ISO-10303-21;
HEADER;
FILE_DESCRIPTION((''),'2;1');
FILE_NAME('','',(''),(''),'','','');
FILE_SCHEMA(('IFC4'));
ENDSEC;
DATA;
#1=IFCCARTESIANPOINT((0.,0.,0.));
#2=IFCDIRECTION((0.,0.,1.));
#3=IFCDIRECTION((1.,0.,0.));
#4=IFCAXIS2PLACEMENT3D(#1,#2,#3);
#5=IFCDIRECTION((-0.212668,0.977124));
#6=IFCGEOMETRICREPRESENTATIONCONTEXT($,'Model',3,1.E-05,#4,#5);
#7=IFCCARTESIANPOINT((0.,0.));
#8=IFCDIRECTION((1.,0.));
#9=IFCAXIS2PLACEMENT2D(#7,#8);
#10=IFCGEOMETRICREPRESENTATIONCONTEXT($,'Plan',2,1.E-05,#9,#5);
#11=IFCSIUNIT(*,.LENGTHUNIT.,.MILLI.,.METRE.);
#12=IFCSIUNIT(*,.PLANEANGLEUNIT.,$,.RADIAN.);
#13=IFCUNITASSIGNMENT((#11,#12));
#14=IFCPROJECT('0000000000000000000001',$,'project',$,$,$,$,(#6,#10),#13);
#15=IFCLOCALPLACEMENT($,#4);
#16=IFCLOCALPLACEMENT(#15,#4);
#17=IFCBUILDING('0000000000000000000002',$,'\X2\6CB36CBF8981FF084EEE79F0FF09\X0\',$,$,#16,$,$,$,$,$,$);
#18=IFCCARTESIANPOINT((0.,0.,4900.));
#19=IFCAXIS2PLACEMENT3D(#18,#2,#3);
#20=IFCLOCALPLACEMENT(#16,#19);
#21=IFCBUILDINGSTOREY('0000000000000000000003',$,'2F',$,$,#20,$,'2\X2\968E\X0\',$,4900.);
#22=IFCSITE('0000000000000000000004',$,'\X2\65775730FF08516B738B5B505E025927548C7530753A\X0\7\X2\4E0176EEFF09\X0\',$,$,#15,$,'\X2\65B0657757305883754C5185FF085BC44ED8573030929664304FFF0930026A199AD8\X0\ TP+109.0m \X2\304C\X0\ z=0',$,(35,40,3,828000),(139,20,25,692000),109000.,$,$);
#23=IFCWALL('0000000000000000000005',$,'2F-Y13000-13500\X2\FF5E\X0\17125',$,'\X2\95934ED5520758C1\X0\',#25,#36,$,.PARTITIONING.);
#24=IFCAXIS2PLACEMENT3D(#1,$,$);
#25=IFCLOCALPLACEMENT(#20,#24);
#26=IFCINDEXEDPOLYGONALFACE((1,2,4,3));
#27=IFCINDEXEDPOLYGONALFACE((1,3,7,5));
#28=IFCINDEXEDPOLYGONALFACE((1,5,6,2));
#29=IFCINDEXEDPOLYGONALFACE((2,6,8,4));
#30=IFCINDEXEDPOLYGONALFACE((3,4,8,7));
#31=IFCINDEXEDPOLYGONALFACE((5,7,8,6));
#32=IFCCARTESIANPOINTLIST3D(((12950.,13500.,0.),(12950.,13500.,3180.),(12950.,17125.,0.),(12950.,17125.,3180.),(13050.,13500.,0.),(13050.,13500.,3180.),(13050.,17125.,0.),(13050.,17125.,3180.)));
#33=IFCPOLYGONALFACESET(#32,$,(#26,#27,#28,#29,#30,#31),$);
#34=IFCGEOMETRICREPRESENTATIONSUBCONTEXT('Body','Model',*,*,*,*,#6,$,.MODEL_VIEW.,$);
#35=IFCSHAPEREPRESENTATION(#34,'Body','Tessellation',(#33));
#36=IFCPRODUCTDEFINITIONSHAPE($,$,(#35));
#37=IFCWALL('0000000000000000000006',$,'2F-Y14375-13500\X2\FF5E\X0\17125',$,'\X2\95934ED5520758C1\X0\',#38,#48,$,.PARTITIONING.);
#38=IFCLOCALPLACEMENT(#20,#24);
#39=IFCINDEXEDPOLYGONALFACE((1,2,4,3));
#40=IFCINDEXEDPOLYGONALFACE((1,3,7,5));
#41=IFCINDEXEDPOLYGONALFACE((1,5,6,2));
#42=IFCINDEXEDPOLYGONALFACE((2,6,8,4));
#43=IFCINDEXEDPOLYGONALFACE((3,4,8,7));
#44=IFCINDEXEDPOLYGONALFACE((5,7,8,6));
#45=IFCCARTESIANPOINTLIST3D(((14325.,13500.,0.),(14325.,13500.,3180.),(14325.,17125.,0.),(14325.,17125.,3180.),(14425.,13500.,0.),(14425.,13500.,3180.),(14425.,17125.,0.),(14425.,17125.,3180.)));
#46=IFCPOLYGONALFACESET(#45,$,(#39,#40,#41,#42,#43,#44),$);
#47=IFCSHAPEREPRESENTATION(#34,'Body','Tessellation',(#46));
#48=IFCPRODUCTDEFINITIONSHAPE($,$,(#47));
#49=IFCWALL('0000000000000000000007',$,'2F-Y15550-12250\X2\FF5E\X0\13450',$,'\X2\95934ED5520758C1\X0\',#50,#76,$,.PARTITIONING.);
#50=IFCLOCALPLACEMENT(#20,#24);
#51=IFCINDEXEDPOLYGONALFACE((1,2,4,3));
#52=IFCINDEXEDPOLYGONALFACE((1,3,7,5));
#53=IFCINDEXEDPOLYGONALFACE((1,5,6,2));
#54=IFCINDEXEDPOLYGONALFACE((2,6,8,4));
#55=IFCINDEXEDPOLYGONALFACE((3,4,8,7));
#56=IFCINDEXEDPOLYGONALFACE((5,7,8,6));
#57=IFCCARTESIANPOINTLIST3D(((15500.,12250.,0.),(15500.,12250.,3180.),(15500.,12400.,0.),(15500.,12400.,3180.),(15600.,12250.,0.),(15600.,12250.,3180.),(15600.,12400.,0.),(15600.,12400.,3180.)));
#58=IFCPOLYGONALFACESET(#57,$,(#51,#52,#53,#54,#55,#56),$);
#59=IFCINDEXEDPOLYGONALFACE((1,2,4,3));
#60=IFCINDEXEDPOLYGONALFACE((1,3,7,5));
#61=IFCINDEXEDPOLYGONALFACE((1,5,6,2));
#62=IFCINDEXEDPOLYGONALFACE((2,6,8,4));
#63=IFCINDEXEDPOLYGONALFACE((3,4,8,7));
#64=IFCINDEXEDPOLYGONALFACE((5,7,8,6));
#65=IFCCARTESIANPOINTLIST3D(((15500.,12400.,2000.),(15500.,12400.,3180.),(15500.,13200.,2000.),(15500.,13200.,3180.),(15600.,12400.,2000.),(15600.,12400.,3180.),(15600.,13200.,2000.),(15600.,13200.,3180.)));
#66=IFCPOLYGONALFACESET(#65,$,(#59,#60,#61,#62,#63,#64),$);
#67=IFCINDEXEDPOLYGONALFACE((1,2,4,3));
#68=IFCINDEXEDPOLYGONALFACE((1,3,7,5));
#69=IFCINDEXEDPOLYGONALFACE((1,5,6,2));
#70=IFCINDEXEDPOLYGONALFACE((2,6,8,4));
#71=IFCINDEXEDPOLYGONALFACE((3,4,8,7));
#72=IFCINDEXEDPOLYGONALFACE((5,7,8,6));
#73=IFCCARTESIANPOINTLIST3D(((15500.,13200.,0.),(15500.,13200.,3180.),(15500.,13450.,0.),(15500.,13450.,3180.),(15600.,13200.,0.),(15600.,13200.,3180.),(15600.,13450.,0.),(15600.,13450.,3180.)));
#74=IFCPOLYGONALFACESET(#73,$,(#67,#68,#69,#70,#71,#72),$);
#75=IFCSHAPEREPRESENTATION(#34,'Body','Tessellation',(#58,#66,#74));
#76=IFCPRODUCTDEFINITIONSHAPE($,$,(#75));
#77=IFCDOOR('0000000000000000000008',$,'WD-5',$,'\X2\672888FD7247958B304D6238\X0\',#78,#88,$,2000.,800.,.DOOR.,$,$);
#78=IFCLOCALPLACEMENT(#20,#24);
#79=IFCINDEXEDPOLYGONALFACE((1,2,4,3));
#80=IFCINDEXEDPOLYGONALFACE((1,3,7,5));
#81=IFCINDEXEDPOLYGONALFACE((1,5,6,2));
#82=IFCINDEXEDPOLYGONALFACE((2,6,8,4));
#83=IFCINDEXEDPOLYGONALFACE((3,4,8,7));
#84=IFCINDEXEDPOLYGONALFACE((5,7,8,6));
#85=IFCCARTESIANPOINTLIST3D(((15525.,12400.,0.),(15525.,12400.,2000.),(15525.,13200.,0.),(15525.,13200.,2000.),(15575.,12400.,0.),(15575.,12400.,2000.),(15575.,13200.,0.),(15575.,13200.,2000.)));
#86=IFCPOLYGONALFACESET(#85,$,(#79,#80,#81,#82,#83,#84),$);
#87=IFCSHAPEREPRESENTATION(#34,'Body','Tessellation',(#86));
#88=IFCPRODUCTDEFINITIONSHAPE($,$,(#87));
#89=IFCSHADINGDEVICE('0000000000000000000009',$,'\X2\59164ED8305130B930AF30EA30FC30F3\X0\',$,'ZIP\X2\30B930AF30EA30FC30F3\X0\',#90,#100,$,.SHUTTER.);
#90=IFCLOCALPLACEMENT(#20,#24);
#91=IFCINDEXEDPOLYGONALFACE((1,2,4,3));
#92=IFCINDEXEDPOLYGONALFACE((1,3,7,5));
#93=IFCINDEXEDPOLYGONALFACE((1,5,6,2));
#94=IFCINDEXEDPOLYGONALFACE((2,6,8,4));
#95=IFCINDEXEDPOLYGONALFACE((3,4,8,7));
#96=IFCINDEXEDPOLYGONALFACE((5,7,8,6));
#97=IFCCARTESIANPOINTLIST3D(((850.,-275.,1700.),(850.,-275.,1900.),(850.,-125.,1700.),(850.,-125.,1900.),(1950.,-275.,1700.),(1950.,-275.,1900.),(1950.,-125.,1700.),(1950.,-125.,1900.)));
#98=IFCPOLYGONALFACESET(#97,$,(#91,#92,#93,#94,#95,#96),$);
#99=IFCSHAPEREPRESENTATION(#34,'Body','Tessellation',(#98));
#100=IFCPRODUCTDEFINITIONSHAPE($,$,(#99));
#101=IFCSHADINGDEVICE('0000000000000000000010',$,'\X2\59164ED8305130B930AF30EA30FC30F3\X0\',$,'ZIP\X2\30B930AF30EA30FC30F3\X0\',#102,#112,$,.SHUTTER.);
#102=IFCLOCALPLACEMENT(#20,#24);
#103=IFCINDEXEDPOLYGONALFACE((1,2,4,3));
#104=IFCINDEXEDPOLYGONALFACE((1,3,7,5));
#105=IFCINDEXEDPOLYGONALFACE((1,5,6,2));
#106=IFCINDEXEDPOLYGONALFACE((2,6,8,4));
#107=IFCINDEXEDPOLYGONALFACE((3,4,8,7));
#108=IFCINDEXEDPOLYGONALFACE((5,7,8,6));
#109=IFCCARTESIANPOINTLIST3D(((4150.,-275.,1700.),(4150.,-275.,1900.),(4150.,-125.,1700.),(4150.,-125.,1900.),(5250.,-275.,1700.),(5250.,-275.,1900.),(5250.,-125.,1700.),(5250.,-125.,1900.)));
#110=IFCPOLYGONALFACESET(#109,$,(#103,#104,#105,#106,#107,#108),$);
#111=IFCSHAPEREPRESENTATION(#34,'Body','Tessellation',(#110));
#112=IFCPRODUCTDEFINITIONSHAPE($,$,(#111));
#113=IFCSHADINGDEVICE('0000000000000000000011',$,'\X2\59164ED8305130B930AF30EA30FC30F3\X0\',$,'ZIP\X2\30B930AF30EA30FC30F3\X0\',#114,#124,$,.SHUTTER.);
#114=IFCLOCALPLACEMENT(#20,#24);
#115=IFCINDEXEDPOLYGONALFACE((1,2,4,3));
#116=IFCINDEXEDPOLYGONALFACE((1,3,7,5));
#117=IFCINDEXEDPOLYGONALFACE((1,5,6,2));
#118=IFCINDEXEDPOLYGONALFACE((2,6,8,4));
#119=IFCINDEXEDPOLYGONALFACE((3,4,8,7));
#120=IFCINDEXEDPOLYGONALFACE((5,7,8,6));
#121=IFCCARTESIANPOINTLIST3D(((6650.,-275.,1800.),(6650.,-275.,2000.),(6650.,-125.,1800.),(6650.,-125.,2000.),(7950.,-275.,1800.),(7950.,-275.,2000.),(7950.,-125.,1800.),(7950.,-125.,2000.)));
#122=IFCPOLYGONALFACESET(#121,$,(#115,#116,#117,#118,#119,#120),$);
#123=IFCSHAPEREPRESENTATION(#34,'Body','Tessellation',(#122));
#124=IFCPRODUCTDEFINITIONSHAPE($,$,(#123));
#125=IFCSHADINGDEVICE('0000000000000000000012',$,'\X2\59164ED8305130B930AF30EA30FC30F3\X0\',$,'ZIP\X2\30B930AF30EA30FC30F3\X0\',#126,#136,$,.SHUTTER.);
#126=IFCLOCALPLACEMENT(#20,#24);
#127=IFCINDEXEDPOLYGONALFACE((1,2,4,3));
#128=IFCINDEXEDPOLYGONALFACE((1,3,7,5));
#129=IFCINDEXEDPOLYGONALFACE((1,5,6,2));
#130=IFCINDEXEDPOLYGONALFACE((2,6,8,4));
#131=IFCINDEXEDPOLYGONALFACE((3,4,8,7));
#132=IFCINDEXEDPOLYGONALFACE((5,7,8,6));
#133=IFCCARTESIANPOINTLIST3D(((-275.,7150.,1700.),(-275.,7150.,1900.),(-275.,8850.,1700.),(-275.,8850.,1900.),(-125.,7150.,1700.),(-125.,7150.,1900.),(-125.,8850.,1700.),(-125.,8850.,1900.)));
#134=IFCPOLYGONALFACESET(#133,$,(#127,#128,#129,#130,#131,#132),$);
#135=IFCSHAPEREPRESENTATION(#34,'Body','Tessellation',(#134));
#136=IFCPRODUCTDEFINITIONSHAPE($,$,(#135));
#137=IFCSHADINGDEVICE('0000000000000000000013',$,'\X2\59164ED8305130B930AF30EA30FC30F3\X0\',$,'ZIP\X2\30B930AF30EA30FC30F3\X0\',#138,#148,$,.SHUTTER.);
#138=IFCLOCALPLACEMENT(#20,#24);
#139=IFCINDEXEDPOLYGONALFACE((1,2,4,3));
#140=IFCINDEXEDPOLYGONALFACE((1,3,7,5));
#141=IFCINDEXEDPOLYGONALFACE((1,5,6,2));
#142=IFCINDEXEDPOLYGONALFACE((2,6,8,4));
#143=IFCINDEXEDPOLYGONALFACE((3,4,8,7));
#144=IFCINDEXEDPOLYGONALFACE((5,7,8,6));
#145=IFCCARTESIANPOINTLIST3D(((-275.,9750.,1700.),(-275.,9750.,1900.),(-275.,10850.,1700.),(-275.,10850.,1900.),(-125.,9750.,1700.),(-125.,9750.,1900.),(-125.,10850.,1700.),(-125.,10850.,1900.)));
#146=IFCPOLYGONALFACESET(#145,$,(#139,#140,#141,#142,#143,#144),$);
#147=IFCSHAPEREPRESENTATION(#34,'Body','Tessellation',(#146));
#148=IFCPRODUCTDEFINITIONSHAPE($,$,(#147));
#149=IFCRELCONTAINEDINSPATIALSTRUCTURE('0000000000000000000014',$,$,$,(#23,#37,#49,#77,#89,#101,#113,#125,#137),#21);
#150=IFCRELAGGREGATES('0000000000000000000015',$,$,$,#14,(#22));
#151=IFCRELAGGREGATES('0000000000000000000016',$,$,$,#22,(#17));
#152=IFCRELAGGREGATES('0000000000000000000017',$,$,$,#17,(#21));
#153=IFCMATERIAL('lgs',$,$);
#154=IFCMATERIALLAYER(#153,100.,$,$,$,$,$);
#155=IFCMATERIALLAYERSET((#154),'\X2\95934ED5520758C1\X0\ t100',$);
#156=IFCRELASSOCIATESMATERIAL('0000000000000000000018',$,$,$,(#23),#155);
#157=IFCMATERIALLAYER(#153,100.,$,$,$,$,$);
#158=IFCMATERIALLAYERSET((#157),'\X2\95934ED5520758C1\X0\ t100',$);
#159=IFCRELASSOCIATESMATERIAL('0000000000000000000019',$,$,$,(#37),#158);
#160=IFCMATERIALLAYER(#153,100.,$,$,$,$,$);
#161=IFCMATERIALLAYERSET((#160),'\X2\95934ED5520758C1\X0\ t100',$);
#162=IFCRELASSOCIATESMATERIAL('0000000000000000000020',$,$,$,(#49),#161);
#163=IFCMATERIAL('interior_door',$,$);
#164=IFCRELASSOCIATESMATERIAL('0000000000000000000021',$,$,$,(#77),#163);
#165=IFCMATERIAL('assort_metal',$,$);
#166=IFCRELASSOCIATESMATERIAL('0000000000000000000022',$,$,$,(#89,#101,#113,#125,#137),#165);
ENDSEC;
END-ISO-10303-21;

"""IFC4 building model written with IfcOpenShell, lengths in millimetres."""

from ifc_helpers import new_model, si_unit, direction, frame, frame_2d, origin, origin_with_axes, origin_2d_with_axis, place, context, subcontext, project, spatial, rectangle, extrude, material, layer, layer_set, layer_usage, element, fill, save


model = new_model("IFC4")

# Units and contexts
model_context = context("Model", 3, precision=1e-05, world=origin_with_axes(), true_north=direction((-0.212668, 0.977124)))
plan_context = context("Plan", 2, precision=1e-05, world=origin_2d_with_axis(), true_north=direction((-0.212668, 0.977124)))
body_context = subcontext(model_context, "Body", "Model", "MODEL_VIEW")
ifc_project = project(units=[si_unit("LENGTHUNIT", "METRE", prefix="MILLI"), si_unit("PLANEANGLEUNIT", "RADIAN")], contexts=[model_context, plan_context])

# Site, building, storey
site_placement = place(None, origin_with_axes())
site = spatial("IfcSite", under=ifc_project, at=site_placement, Name="敷地（八王子市大和田町7丁目）", LongName="新敷地境界内（寄付地を除く）。標高 TP+109.0m が z=0", RefLatitude=(35, 40, 3, 828000), RefLongitude=(139, 20, 25, 692000), RefElevation=109000.0)
building_placement = place(site_placement, origin_with_axes())
building = spatial("IfcBuilding", under=site, at=building_placement, Name="河沿要（仮称）")
storey_placement = place(building_placement, frame((0.0, 0.0, 4900.0), z_axis=(0.0, 0.0, 1.0), x_axis=(1.0, 0.0, 0.0)))
storey = spatial("IfcBuildingStorey", under=building, at=storey_placement, Name="2F", LongName="2階", Elevation=4900.0)

# Shared definitions
ifc_material_1 = material(Name="lgs")

# Shared definitions
ifc_material_2 = material(Name="interior_door")

# Walls
ifc_layer_1 = layer(ifc_material_1, 100.0)
ifc_layer_set_1 = layer_set([ifc_layer_1], Name="間仕切壁 t100")
ifc_layer_usage_1 = layer_usage(ifc_layer_set_1, "AXIS2", "POSITIVE", 0.0)
wall_1_placement = place(storey_placement, origin_with_axes())
element("IfcWall", 1, at=wall_1_placement, inside=storey, material=ifc_layer_usage_1, Name="2F-Y13000-13500～17125", ObjectType="間仕切壁", PredefinedType="PARTITIONING", context=body_context, shape_type="SweptSolid", body=[
    extrude(rectangle(XDim=100.0, YDim=3625.0, at=frame_2d((13000.0, 15312.5))), origin(), (0.0, 0.0, 1.0), 3180.0),
])
ifc_layer_2 = layer(ifc_material_1, 100.0)
ifc_layer_set_2 = layer_set([ifc_layer_2], Name="間仕切壁 t100")
ifc_layer_usage_2 = layer_usage(ifc_layer_set_2, "AXIS2", "POSITIVE", 0.0)
wall_2_placement = place(storey_placement, origin_with_axes())
element("IfcWall", 2, at=wall_2_placement, inside=storey, material=ifc_layer_usage_2, Name="2F-Y14375-13500～17125", ObjectType="間仕切壁", PredefinedType="PARTITIONING", context=body_context, shape_type="SweptSolid", body=[
    extrude(rectangle(XDim=100.0, YDim=3625.0, at=frame_2d((14375.0, 15312.5))), origin(), (0.0, 0.0, 1.0), 3180.0),
])

# Wall, opening, door
ifc_layer_3 = layer(ifc_material_1, 100.0)
ifc_layer_set_3 = layer_set([ifc_layer_3], Name="間仕切壁 t100")
ifc_layer_usage_3 = layer_usage(ifc_layer_set_3, "AXIS2", "POSITIVE", 0.0)
wall_3_placement = place(storey_placement, origin_with_axes())
wall_3 = element("IfcWall", 3, at=wall_3_placement, inside=storey, material=ifc_layer_usage_3, Name="2F-Y15550-12250～13450", ObjectType="間仕切壁", PredefinedType="PARTITIONING", context=body_context, shape_type="SweptSolid", body=[
    extrude(rectangle(XDim=100.0, YDim=150.0, at=frame_2d((15550.0, 12325.0))), origin(), (0.0, 0.0, 1.0), 3180.0),
    extrude(rectangle(XDim=100.0, YDim=800.0, at=frame_2d((15550.0, 12800.0))), frame((0.0, 0.0, 2000.0)), (0.0, 0.0, 1.0), 1180.0),
    extrude(rectangle(XDim=100.0, YDim=250.0, at=frame_2d((15550.0, 13325.0))), origin(), (0.0, 0.0, 1.0), 3180.0),
])
opening_1_placement = place(storey_placement, origin_with_axes())
opening_1 = element("IfcOpeningElement", 4, at=opening_1_placement, inside=storey, cuts=wall_3, PredefinedType="OPENING", context=body_context, shape_type="SweptSolid", body=[
    extrude(rectangle(XDim=150.0, YDim=800.0, at=frame_2d((15550.0, 12800.0))), origin(), (0.0, 0.0, 1.0), 2000.0),
])
door_1_placement = place(storey_placement, origin_with_axes())
door_1 = element("IfcDoor", 5, at=door_1_placement, inside=storey, material=ifc_material_2, Name="WD-5", ObjectType="木製片開き戸", OverallHeight=2000.0, OverallWidth=800.0, PredefinedType="DOOR", context=body_context, shape_type="SweptSolid", body=[
    extrude(rectangle(XDim=50.0, YDim=800.0, at=frame_2d((15550.0, 12800.0))), origin(), (0.0, 0.0, 1.0), 2000.0),
])
fill(opening_1, door_1)

# Shading devices
ifc_material_3 = material(Name="assort_metal")
shading_device_1_placement = place(storey_placement, origin_with_axes())
element("IfcShadingDevice", 6, at=shading_device_1_placement, inside=storey, material=ifc_material_3, Name="外付けスクリーン", ObjectType="ZIPスクリーン", PredefinedType="SHUTTER", context=body_context, shape_type="SweptSolid", body=[
    extrude(rectangle(XDim=1100.0, YDim=150.0, at=frame_2d((1400.0, -200.0))), frame((0.0, 0.0, 1700.0)), (0.0, 0.0, 1.0), 200.0),
])
shading_device_2_placement = place(storey_placement, origin_with_axes())
element("IfcShadingDevice", 7, at=shading_device_2_placement, inside=storey, material=ifc_material_3, Name="外付けスクリーン", ObjectType="ZIPスクリーン", PredefinedType="SHUTTER", context=body_context, shape_type="SweptSolid", body=[
    extrude(rectangle(XDim=1100.0, YDim=150.0, at=frame_2d((4700.0, -200.0))), frame((0.0, 0.0, 1700.0)), (0.0, 0.0, 1.0), 200.0),
])
shading_device_3_placement = place(storey_placement, origin_with_axes())
element("IfcShadingDevice", 8, at=shading_device_3_placement, inside=storey, material=ifc_material_3, Name="外付けスクリーン", ObjectType="ZIPスクリーン", PredefinedType="SHUTTER", context=body_context, shape_type="SweptSolid", body=[
    extrude(rectangle(XDim=1300.0, YDim=150.0, at=frame_2d((7300.0, -200.0))), frame((0.0, 0.0, 1800.0)), (0.0, 0.0, 1.0), 200.0),
])
shading_device_4_placement = place(storey_placement, origin_with_axes())
element("IfcShadingDevice", 9, at=shading_device_4_placement, inside=storey, material=ifc_material_3, Name="外付けスクリーン", ObjectType="ZIPスクリーン", PredefinedType="SHUTTER", context=body_context, shape_type="SweptSolid", body=[
    extrude(rectangle(XDim=150.0, YDim=1700.0, at=frame_2d((-200.0, 8000.0))), frame((0.0, 0.0, 1700.0)), (0.0, 0.0, 1.0), 200.0),
])
shading_device_5_placement = place(storey_placement, origin_with_axes())
element("IfcShadingDevice", 10, at=shading_device_5_placement, inside=storey, material=ifc_material_3, Name="外付けスクリーン", ObjectType="ZIPスクリーン", PredefinedType="SHUTTER", context=body_context, shape_type="SweptSolid", body=[
    extrude(rectangle(XDim=150.0, YDim=1100.0, at=frame_2d((-200.0, 10300.0))), frame((0.0, 0.0, 1700.0)), (0.0, 0.0, 1.0), 200.0),
])

save(model, "model.ifc")
